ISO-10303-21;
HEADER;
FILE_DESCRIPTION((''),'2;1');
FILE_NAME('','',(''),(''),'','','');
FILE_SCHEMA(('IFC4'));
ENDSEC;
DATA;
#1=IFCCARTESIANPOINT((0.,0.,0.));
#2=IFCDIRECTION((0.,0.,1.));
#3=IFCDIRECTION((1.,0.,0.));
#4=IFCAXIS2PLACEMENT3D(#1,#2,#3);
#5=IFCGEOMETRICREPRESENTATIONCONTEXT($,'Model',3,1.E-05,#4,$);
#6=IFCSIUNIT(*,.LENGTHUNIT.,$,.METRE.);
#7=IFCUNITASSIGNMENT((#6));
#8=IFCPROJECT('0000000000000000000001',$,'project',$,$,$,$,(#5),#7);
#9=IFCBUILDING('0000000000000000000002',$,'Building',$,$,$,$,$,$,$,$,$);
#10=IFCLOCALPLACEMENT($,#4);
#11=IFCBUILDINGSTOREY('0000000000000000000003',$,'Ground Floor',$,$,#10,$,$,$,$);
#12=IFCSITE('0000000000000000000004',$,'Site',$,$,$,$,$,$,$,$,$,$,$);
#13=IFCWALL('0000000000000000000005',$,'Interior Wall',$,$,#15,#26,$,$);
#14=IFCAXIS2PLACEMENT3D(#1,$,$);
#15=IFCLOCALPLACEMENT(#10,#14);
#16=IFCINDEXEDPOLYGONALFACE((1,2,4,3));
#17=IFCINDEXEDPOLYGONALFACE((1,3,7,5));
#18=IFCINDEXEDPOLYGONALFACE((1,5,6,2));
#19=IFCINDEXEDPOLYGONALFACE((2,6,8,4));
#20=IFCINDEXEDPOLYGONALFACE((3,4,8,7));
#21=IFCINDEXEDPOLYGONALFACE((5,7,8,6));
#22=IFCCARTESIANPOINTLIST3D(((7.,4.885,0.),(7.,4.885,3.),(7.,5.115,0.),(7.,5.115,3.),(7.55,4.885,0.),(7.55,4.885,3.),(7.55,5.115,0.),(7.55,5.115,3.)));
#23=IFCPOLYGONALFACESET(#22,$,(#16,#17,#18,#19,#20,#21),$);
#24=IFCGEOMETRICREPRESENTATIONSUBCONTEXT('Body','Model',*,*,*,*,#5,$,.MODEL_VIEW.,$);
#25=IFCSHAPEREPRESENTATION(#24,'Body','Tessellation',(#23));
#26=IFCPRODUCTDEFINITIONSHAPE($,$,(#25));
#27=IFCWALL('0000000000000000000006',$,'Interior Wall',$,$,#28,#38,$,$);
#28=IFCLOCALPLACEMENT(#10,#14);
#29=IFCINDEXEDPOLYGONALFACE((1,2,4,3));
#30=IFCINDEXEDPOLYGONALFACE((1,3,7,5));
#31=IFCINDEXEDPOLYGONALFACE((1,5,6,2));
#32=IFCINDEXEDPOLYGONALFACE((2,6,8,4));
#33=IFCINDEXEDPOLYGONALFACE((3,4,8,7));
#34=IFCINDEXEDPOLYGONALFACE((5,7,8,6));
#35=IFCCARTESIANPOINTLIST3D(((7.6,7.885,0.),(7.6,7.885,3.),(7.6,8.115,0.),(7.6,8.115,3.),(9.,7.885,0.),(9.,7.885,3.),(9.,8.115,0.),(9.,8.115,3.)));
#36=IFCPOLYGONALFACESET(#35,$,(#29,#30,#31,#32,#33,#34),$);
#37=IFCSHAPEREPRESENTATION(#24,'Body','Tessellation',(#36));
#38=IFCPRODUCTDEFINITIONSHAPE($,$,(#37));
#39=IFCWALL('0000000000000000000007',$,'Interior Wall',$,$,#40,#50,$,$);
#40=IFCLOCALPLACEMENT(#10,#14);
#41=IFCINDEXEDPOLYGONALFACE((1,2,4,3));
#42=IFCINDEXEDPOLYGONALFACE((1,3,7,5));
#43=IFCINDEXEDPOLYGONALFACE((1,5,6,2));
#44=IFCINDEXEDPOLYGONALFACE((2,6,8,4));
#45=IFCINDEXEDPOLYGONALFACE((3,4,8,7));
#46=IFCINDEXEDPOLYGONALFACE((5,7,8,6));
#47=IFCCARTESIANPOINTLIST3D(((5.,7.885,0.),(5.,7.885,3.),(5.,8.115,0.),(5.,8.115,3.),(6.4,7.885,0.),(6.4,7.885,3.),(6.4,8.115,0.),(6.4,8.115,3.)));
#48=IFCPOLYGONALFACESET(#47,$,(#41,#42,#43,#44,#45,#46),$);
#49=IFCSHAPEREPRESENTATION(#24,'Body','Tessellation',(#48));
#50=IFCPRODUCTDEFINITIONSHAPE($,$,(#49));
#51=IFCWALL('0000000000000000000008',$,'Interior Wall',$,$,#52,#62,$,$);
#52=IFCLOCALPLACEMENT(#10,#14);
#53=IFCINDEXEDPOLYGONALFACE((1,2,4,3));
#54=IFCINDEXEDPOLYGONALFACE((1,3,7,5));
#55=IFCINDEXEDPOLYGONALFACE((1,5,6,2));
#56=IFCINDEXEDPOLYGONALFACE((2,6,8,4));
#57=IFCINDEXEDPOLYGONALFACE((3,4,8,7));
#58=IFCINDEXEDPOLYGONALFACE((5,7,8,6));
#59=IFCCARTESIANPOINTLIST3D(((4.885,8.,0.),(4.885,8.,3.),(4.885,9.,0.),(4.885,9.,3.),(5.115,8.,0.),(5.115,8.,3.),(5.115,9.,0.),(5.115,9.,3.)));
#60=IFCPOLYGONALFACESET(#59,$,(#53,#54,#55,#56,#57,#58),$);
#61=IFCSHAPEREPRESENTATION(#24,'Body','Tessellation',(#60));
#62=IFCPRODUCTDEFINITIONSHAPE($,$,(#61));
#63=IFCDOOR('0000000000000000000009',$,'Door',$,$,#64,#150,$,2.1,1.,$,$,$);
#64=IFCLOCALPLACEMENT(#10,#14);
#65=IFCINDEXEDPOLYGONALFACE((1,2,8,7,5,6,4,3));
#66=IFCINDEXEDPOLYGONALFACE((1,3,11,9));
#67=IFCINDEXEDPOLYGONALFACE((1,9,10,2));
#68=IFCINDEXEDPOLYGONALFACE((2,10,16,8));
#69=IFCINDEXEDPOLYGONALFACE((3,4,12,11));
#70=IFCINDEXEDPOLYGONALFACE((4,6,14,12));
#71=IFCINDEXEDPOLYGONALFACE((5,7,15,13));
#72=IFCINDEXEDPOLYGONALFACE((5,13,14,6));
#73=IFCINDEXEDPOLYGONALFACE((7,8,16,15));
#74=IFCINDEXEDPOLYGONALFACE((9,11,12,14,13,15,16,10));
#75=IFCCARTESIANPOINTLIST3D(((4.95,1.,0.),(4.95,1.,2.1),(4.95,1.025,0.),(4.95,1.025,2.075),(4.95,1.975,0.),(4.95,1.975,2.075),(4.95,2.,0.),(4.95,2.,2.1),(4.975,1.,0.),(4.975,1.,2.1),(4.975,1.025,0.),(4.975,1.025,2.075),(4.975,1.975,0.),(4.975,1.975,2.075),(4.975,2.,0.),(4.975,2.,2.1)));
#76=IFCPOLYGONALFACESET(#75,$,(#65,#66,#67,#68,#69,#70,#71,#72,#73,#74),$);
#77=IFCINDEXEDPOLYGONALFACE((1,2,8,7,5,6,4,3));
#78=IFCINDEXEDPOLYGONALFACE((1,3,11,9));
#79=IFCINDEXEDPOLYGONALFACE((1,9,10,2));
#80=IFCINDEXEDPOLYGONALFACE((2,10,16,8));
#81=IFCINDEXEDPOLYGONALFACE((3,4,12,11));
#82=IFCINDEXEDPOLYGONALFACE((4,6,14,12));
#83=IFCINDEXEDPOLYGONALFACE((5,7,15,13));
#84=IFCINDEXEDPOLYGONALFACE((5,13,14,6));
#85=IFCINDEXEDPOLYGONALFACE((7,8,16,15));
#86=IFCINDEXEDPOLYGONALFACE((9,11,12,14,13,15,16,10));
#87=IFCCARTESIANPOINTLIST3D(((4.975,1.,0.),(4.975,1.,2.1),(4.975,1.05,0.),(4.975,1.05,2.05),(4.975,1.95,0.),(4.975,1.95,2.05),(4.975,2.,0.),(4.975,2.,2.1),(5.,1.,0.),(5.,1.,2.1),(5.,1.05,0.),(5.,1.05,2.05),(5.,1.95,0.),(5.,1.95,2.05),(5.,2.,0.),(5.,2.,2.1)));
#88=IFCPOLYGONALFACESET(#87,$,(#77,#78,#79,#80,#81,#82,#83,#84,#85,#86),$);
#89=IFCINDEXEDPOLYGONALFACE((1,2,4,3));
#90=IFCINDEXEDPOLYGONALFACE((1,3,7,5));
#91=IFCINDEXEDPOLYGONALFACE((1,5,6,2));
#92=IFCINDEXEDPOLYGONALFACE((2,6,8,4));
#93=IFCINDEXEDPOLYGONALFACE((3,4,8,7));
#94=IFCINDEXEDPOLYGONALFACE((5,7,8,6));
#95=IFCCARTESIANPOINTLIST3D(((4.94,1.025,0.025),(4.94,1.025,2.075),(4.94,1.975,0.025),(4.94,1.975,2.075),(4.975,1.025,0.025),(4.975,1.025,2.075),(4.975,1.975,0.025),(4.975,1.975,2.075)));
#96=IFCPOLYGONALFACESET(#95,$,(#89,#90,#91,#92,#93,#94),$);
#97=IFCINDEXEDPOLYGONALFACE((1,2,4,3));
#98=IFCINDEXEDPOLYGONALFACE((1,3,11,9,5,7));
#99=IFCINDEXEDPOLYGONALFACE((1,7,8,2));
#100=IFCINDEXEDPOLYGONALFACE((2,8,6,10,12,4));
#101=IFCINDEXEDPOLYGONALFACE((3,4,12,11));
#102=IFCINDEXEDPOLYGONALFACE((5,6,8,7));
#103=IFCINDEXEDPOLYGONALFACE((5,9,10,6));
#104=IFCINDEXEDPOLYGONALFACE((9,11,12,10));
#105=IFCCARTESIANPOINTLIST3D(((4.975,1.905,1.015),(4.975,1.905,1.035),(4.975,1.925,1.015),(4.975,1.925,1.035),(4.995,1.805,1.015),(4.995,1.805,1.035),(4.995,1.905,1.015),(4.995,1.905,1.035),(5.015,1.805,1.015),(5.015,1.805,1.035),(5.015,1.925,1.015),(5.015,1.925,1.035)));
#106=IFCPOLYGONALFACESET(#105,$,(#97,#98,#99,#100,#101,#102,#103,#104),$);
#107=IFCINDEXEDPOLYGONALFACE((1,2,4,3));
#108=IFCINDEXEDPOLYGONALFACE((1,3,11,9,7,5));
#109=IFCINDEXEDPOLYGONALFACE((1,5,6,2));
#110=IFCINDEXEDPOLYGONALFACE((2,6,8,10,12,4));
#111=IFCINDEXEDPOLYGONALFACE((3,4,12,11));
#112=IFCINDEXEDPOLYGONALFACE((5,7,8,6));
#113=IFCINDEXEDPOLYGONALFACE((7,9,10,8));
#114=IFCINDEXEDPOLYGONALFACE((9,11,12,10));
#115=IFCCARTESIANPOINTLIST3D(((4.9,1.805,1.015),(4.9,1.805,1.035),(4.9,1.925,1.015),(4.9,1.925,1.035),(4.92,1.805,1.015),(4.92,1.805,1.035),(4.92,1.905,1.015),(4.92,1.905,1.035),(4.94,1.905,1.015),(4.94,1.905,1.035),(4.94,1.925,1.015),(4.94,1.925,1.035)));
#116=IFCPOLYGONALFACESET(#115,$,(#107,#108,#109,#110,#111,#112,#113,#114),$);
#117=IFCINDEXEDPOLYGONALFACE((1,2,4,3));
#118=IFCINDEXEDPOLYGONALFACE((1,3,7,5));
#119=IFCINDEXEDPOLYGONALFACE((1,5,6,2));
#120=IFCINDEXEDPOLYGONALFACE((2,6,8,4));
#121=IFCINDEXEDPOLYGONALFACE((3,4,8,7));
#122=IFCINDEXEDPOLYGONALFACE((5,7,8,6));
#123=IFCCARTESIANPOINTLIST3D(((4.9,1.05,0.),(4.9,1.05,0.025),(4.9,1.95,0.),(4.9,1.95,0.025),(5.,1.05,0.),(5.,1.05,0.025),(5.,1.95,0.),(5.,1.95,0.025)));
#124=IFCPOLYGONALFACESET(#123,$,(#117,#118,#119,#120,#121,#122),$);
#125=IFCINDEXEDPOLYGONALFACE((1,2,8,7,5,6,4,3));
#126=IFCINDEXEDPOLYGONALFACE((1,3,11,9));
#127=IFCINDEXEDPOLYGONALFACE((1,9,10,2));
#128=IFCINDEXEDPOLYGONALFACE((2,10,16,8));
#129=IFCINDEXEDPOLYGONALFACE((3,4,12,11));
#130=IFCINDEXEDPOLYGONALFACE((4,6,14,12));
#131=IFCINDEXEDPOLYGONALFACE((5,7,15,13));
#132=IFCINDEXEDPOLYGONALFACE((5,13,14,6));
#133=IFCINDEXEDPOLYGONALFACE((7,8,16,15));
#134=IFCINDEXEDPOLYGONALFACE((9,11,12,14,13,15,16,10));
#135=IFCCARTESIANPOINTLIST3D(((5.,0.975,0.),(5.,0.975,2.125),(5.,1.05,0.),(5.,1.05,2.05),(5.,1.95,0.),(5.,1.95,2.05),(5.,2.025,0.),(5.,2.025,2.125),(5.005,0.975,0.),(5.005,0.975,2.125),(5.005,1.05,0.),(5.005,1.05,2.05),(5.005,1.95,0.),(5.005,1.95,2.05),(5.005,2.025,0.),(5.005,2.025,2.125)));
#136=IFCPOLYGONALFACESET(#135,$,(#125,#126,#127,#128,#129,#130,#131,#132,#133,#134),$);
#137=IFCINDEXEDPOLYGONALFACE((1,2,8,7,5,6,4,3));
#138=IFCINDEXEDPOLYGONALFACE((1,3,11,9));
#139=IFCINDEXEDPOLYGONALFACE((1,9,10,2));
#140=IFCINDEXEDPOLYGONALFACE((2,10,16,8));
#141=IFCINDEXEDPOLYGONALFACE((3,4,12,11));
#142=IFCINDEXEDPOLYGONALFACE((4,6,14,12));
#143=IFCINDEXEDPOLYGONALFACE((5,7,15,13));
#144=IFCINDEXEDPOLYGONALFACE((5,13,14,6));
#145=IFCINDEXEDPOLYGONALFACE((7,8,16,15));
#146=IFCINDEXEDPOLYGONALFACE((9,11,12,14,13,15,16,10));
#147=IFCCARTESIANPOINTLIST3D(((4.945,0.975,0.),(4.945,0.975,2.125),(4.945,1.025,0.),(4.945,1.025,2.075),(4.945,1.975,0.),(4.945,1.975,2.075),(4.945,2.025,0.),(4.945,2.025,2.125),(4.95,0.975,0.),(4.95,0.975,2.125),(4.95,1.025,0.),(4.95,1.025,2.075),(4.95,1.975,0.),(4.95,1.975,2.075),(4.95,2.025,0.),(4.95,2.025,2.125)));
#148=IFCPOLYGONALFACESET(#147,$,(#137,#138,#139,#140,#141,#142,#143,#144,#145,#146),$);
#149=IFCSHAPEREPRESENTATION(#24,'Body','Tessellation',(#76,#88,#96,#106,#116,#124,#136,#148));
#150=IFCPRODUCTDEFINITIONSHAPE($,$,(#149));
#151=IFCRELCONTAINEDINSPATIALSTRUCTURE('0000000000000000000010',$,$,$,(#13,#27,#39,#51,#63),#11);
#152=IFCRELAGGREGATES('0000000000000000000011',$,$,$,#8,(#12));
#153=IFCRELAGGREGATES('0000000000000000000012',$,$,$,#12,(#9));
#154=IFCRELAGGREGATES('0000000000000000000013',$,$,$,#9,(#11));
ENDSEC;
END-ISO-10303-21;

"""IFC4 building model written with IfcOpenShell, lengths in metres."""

from ifc_helpers import new_model, si_unit, frame, origin_with_axes, place, context, subcontext, project, spatial, line, indexed_curve, outline, extrude, element, save


model = new_model("IFC4")

# Units and contexts
model_context = context("Model", 3, precision=1e-05, world=origin_with_axes())
body_context = subcontext(model_context, "Body", "Model", "MODEL_VIEW")
ifc_project = project(units=[si_unit("LENGTHUNIT", "METRE")], contexts=[model_context])

# Site, building, storey
site = spatial("IfcSite", under=ifc_project, Name="Site")
building = spatial("IfcBuilding", under=site, Name="Building")
storey_placement = place(None, origin_with_axes())
storey = spatial("IfcBuildingStorey", under=building, at=storey_placement, Name="Ground Floor")

# Walls
wall_1_placement = place(storey_placement, frame((7.55, 5.0, 0.0), z_axis=(0.0, 0.0, 1.0), x_axis=(-1.0, 0.0, 0.0)))
element("IfcWall", 1, at=wall_1_placement, inside=storey, Name="Interior Wall", context=body_context, shape_type="SweptSolid", body=[
    extrude(outline(indexed_curve([(0.0, 0.0), (0.0, 0.23), (0.55, 0.23), (0.55, 0.0), (0.0, 0.0)], self_intersect=False)), frame((0.0, -0.115, 0.0), z_axis=(0.0, 0.0, 1.0), x_axis=(1.0, 0.0, 0.0)), (0.0, 0.0, 1.0), 3.0),
])
for number, where, z_axis, x_axis, name in (
    (2, (9.0, 8.0, 0.0), (0.0, 0.0, 1.0), (-1.0, 0.0, 0.0), "Interior Wall"),
    (3, (6.4, 8.0, 0.0), (0.0, 0.0, 1.0), (-1.0, 0.0, 0.0), "Interior Wall"),
):
    element("IfcWall", number, at=place(storey_placement, frame(where, z_axis=z_axis, x_axis=x_axis)), inside=storey, Name=name, context=body_context, shape_type="SweptSolid", body=[
        extrude(outline(indexed_curve([(0.0, 0.0), (0.0, 0.23), (1.4, 0.23), (1.4, 0.0), (0.0, 0.0)], self_intersect=False)), frame((0.0, -0.115, 0.0), z_axis=(0.0, 0.0, 1.0), x_axis=(1.0, 0.0, 0.0)), (0.0, 0.0, 1.0), 3.0),
    ])
wall_2_placement = place(storey_placement, frame((5.0, 8.0, 0.0), z_axis=(0.0, 0.0, 1.0), x_axis=(0.0, 1.0, 0.0)))
element("IfcWall", 4, at=wall_2_placement, inside=storey, Name="Interior Wall", context=body_context, shape_type="SweptSolid", body=[
    extrude(outline(indexed_curve([(0.0, 0.0), (0.0, 0.23), (1.0, 0.23), (1.0, 0.0), (0.0, 0.0)], self_intersect=False)), frame((0.0, -0.115, 0.0), z_axis=(0.0, 0.0, 1.0), x_axis=(1.0, 0.0, 0.0)), (0.0, 0.0, 1.0), 3.0),
])

# Door
door_1_placement = place(storey_placement, frame((5.0, 1.0, 0.0), z_axis=(0.0, 0.0, 1.0), x_axis=(0.0, 1.0, 0.0)))
element("IfcDoor", 5, at=door_1_placement, inside=storey, Name="Door", OverallHeight=2.1, OverallWidth=1.0, context=body_context, shape_type="SweptSolid", body=[
    extrude(outline(indexed_curve([(0.0, 0.0), (0.0, 2.1), (1.0, 2.1), (1.0, 0.0), (0.975, 0.0), (0.975, 2.075), (0.025, 2.075), (0.025, 0.0)], segments=[line(1, 2, 3, 4, 5, 6, 7, 8, 1)])), frame((0.0, 0.025, 0.0), z_axis=(0.0, -1.0, 0.0), x_axis=(1.0, 0.0, 0.0)), (0.0, 0.0, -1.0), 0.025),
    extrude(outline(indexed_curve([(0.0, 0.0), (0.0, 2.1), (1.0, 2.1), (1.0, 0.0), (0.95, 0.0), (0.95, 2.05), (0.05, 2.05), (0.05, 0.0)], segments=[line(1, 2, 3, 4, 5, 6, 7, 8, 1)])), frame((0.0, 0.0, 0.0), z_axis=(0.0, -1.0, 0.0), x_axis=(1.0, 0.0, 0.0)), (0.0, 0.0, -1.0), 0.025),
    extrude(outline(indexed_curve([(0.0, 0.0), (0.95, 0.0), (0.95, 0.035), (0.0, 0.035)], segments=[line(1, 2, 3, 4, 1)])), frame((0.025, 0.025, 0.025), z_axis=(0.0, 0.0, 1.0), x_axis=(1.0, 0.0, 0.0)), (0.0, 0.0, 1.0), 2.05),
    extrude(outline(indexed_curve([(0.0, 0.0), (0.0, -0.04), (-0.12, -0.04), (-0.12, -0.02), (-0.02, -0.02), (-0.02, 0.0)], segments=[line(1, 2, 3, 4, 5, 6, 1)])), frame((0.925, 0.025, 1.015), z_axis=(0.0, 0.0, 1.0), x_axis=(1.0, 0.0, 0.0)), (0.0, 0.0, 1.0), 0.02),
    extrude(outline(indexed_curve([(0.0, 0.0), (0.0, 0.04), (-0.12, 0.04), (-0.12, 0.02), (-0.02, 0.02), (-0.02, 0.0)], segments=[line(1, 2, 3, 4, 5, 6, 1)])), frame((0.925, 0.06, 1.015), z_axis=(0.0, 0.0, 1.0), x_axis=(1.0, 0.0, 0.0)), (0.0, 0.0, 1.0), 0.02),
    extrude(outline(indexed_curve([(0.0, 0.0), (0.9, 0.0), (0.9, 0.1), (0.0, 0.1)], segments=[line(1, 2, 3, 4, 1)])), frame((0.05, 0.0, 0.0), z_axis=(0.0, 0.0, 1.0), x_axis=(1.0, 0.0, 0.0)), (0.0, 0.0, 1.0), 0.025),
    extrude(outline(indexed_curve([(0.0, 0.0), (0.0, 2.125), (1.05, 2.125), (1.05, 0.0), (0.975, 0.0), (0.975, 2.05), (0.075, 2.05), (0.075, 0.0)], segments=[line(1, 2, 3, 4, 5, 6, 7, 8, 1)])), frame((-0.025, -0.005, 0.0), z_axis=(0.0, -1.0, 0.0), x_axis=(1.0, 0.0, 0.0)), (0.0, 0.0, -1.0), 0.005),
    extrude(outline(indexed_curve([(0.0, 0.0), (0.0, 2.125), (1.05, 2.125), (1.05, 0.0), (1.0, 0.0), (1.0, 2.075), (0.05, 2.075), (0.05, 0.0)], segments=[line(1, 2, 3, 4, 5, 6, 7, 8, 1)])), frame((-0.025, 0.05, 0.0), z_axis=(0.0, -1.0, 0.0), x_axis=(1.0, 0.0, 0.0)), (0.0, 0.0, -1.0), 0.005),
])

save(model, "model.ifc")
